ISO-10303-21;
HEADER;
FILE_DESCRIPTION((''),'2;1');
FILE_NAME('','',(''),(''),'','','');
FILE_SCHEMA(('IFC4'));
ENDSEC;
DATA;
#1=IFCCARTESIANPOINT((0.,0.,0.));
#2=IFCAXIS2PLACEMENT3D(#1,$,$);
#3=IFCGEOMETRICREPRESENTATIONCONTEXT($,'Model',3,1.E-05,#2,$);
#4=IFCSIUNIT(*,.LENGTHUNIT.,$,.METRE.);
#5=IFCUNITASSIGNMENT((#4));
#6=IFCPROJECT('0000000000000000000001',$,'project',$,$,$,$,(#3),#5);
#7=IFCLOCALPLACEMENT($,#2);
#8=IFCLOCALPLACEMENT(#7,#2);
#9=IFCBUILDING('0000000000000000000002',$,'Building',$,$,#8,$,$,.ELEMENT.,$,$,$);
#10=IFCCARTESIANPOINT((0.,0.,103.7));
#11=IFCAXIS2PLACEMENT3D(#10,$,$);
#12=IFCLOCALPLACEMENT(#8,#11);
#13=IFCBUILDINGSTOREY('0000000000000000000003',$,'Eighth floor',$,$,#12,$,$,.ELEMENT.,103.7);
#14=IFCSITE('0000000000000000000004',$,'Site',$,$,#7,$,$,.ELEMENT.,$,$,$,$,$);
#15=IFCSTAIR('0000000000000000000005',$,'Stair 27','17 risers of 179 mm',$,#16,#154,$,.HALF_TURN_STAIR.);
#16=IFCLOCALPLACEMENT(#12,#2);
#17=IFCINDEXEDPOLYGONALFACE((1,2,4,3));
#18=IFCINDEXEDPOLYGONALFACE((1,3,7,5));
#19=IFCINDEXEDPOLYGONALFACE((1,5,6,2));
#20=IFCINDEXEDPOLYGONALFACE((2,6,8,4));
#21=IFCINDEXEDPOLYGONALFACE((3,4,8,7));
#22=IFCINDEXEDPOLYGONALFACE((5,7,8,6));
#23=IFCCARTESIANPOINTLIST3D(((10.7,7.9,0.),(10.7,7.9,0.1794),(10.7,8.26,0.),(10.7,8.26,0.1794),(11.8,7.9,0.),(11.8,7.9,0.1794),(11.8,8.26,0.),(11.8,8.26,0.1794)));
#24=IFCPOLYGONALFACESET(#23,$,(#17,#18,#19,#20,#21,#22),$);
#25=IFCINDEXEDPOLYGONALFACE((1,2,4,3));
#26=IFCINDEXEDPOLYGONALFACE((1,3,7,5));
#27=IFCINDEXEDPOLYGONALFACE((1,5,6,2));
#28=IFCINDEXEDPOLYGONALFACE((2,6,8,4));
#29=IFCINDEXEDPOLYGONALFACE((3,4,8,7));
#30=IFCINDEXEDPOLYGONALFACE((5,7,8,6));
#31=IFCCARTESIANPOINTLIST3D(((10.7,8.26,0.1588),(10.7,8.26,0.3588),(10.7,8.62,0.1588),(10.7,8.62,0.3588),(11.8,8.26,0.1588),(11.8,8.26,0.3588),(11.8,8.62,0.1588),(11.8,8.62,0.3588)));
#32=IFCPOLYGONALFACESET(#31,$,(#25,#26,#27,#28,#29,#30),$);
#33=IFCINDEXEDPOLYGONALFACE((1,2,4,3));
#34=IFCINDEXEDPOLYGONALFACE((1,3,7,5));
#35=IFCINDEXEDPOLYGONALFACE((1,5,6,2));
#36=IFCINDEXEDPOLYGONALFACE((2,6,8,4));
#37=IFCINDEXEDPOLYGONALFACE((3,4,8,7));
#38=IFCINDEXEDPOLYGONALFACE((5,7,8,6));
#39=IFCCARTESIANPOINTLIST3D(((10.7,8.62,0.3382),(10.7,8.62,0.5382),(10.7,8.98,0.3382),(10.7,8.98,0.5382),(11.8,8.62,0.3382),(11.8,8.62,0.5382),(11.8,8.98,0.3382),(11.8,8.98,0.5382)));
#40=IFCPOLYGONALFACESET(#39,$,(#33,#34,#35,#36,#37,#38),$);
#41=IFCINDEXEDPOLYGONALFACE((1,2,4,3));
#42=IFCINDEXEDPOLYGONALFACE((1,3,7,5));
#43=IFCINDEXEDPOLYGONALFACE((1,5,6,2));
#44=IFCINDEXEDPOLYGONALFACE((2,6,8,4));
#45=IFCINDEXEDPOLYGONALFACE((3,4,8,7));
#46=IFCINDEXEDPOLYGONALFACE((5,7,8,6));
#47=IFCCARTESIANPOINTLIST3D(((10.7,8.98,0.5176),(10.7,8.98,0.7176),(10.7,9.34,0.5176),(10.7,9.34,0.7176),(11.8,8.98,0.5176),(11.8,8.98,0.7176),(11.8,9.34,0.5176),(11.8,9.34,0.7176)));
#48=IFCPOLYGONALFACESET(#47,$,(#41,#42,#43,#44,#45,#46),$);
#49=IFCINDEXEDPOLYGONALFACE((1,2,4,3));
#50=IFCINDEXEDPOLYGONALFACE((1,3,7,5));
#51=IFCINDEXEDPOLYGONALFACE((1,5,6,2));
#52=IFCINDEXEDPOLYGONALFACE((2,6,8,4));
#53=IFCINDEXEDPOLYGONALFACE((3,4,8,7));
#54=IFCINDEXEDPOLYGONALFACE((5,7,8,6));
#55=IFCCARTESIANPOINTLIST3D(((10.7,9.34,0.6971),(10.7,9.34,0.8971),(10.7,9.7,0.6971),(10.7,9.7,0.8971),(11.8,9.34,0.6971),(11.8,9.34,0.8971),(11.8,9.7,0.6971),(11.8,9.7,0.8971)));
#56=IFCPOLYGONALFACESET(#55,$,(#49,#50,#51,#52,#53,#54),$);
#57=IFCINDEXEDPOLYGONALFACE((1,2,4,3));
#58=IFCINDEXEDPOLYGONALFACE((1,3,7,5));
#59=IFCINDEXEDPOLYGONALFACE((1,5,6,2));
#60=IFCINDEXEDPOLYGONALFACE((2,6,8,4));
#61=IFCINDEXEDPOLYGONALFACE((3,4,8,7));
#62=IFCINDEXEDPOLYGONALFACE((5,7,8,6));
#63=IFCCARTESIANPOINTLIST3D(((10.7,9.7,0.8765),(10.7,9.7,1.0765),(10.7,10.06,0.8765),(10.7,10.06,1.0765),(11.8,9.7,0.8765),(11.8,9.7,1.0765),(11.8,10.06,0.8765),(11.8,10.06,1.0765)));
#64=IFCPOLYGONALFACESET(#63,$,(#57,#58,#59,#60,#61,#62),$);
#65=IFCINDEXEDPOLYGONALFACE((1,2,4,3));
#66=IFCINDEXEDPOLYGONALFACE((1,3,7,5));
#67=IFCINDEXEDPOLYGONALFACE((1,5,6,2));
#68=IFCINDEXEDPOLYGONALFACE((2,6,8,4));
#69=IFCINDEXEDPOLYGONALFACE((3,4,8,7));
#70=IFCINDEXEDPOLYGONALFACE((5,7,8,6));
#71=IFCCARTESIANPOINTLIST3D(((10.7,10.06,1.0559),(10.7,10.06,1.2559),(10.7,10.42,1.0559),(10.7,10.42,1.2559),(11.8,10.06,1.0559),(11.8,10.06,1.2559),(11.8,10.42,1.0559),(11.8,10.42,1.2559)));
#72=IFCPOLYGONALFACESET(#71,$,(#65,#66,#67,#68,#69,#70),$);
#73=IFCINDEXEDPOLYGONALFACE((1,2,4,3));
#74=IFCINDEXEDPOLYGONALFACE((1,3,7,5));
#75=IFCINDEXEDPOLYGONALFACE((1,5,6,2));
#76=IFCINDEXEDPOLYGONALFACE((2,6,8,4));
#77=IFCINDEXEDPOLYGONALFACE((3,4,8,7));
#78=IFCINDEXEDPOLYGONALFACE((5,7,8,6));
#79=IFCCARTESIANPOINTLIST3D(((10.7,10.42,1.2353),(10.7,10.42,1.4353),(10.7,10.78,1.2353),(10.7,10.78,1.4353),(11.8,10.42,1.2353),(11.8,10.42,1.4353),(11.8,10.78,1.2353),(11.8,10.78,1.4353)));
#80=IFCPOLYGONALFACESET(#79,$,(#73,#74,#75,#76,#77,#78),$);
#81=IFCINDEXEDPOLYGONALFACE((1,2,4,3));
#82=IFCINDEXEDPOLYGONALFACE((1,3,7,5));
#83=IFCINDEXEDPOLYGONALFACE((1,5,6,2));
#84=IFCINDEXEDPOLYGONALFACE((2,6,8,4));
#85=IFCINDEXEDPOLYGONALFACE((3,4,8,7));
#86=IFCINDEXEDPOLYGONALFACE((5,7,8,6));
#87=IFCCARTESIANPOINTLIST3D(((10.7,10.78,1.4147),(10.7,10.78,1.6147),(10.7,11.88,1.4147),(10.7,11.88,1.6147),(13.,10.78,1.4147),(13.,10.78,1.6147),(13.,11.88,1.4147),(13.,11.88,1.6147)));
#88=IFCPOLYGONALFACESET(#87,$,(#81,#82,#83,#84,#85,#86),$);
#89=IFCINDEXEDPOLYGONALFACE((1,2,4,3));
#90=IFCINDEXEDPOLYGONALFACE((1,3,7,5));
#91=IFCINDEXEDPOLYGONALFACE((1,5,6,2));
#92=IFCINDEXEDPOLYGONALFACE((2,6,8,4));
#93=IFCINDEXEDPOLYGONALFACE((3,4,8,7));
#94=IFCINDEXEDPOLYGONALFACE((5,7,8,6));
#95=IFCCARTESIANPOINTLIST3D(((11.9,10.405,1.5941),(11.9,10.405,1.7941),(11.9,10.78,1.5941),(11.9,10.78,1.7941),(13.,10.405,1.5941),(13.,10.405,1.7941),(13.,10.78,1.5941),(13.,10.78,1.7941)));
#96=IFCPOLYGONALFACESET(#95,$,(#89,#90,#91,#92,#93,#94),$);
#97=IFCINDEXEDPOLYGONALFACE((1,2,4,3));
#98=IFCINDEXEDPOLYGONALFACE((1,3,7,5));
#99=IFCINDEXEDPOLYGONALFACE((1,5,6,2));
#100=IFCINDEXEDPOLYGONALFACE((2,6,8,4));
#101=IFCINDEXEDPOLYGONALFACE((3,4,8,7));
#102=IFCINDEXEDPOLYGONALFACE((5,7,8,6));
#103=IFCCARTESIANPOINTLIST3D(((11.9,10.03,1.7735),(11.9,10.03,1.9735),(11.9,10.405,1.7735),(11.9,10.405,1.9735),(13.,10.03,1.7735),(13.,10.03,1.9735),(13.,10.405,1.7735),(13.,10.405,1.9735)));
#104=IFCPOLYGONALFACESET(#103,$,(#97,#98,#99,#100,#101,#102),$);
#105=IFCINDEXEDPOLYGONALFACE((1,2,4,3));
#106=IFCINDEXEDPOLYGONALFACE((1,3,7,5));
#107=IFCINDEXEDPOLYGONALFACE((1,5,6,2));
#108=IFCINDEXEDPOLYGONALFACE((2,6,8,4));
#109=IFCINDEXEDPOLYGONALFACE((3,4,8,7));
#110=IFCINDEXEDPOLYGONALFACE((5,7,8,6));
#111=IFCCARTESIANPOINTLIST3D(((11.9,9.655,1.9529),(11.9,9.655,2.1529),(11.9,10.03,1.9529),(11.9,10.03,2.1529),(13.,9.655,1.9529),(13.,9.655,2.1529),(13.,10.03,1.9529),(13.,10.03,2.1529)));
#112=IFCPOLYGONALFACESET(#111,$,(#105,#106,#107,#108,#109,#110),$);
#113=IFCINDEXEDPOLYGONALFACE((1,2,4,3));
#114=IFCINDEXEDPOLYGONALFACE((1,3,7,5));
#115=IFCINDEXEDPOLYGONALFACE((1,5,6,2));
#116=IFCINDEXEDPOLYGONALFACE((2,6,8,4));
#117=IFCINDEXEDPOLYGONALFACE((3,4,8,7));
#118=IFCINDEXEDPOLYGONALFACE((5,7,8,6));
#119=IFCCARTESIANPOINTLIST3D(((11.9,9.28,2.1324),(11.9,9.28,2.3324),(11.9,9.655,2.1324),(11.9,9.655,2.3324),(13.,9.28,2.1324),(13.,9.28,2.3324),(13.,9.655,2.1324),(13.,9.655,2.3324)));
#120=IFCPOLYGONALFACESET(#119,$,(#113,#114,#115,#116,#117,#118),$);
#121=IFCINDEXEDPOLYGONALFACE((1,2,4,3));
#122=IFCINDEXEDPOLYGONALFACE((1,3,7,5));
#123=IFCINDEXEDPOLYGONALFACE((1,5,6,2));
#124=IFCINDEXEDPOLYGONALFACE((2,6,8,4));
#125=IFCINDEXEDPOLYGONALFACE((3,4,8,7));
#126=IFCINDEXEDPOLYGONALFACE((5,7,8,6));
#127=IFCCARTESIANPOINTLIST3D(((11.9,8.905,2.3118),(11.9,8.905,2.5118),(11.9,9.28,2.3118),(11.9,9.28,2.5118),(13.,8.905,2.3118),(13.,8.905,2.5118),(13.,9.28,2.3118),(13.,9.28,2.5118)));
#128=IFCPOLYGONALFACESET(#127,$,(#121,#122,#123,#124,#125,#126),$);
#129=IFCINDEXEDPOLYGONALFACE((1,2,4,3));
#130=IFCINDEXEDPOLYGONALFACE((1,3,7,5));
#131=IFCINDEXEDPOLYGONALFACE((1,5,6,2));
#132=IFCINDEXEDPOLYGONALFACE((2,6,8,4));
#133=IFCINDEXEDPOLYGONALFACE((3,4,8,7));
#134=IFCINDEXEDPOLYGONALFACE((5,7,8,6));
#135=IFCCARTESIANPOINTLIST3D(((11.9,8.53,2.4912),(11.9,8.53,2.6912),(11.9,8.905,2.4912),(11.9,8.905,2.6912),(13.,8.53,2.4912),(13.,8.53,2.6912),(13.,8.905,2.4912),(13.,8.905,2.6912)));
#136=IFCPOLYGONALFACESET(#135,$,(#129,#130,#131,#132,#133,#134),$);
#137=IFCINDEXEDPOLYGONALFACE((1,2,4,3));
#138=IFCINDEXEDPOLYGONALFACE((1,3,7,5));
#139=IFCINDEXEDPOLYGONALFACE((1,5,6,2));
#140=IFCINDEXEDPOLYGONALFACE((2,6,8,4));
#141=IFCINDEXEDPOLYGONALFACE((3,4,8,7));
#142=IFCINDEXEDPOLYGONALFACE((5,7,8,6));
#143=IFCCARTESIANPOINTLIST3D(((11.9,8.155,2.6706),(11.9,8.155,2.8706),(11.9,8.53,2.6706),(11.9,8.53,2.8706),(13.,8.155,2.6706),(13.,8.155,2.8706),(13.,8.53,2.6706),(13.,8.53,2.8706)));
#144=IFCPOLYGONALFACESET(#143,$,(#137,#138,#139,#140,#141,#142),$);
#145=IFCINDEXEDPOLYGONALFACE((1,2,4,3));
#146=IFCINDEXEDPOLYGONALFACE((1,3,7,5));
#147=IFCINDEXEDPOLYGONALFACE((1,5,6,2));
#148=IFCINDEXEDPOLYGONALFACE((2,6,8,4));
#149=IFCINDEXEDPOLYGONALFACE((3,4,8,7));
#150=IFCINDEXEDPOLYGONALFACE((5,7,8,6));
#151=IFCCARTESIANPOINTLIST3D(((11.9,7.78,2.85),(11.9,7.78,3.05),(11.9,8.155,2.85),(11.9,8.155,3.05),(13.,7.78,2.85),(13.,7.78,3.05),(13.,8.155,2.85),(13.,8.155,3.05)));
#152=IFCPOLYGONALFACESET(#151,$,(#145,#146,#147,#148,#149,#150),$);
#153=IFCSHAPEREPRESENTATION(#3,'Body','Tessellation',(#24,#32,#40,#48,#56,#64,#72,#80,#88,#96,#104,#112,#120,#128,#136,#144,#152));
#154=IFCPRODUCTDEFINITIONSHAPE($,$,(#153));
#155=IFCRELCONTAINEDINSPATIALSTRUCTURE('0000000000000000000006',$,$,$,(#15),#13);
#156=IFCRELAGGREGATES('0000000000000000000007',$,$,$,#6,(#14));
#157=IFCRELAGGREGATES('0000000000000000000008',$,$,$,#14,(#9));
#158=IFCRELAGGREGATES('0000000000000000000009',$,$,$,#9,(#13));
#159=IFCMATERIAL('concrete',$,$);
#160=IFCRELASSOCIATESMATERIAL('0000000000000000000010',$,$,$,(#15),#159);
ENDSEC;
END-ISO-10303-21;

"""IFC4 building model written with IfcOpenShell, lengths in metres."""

from ifc_helpers import new_model, si_unit, frame, origin, place, context, project, spatial, polyline, outline, extrude, material, element, save


model = new_model("IFC4")

# Units and contexts
model_context = context("Model", 3, precision=1e-05, world=origin())
ifc_project = project(units=[si_unit("LENGTHUNIT", "METRE")], contexts=[model_context])

# Site, building, storey
site_placement = place(None, origin())
site = spatial("IfcSite", under=ifc_project, at=site_placement, Name="Site", CompositionType="ELEMENT")
building_placement = place(site_placement, origin())
building = spatial("IfcBuilding", under=site, at=building_placement, Name="Building", CompositionType="ELEMENT")
storey_placement = place(building_placement, frame((0.0, 0.0, 103.7)))
storey = spatial("IfcBuildingStorey", under=building, at=storey_placement, Name="Eighth floor", CompositionType="ELEMENT", Elevation=103.7)

# Shared definitions
ifc_material = material(Name="concrete")

# Stair
stair_placement = place(storey_placement, frame((11.25, 7.9, 0.0), z_axis=(0.0, 0.0, 1.0), x_axis=(0.0, 1.0, 0.0)))
element("IfcStair", 1, at=stair_placement, inside=storey, material=ifc_material, Name="Stair 27", Description="17 risers of 179 mm", PredefinedType="HALF_TURN_STAIR", context=model_context, shape_type="SweptSolid", body=[
    extrude(outline(polyline([(0.0, -0.55), (0.36, -0.55), (0.36, 0.55), (0.0, 0.55), (0.0, -0.55)])), origin(), (0.0, 0.0, 1.0), 0.1794),
    extrude(outline(polyline([(0.36, -0.55), (0.72, -0.55), (0.72, 0.55), (0.36, 0.55), (0.36, -0.55)])), frame((0.0, 0.0, 0.1588)), (0.0, 0.0, 1.0), 0.2),
    extrude(outline(polyline([(0.72, -0.55), (1.08, -0.55), (1.08, 0.55), (0.72, 0.55), (0.72, -0.55)])), frame((0.0, 0.0, 0.3382)), (0.0, 0.0, 1.0), 0.2),
    extrude(outline(polyline([(1.08, -0.55), (1.44, -0.55), (1.44, 0.55), (1.08, 0.55), (1.08, -0.55)])), frame((0.0, 0.0, 0.5176)), (0.0, 0.0, 1.0), 0.2),
    extrude(outline(polyline([(1.44, -0.55), (1.8, -0.55), (1.8, 0.55), (1.44, 0.55), (1.44, -0.55)])), frame((0.0, 0.0, 0.6971)), (0.0, 0.0, 1.0), 0.2),
    extrude(outline(polyline([(1.8, -0.55), (2.16, -0.55), (2.16, 0.55), (1.8, 0.55), (1.8, -0.55)])), frame((0.0, 0.0, 0.8765)), (0.0, 0.0, 1.0), 0.2),
    extrude(outline(polyline([(2.16, -0.55), (2.52, -0.55), (2.52, 0.55), (2.16, 0.55), (2.16, -0.55)])), frame((0.0, 0.0, 1.0559)), (0.0, 0.0, 1.0), 0.2),
    extrude(outline(polyline([(2.52, -0.55), (2.88, -0.55), (2.88, 0.55), (2.52, 0.55), (2.52, -0.55)])), frame((0.0, 0.0, 1.2353)), (0.0, 0.0, 1.0), 0.2),
    extrude(outline(polyline([(2.88, -1.75), (3.98, -1.75), (3.98, 0.55), (2.88, 0.55), (2.88, -1.75)])), frame((0.0, 0.0, 1.4147)), (0.0, 0.0, 1.0), 0.2),
    extrude(outline(polyline([(2.505, -1.75), (2.88, -1.75), (2.88, -0.65), (2.505, -0.65), (2.505, -1.75)])), frame((0.0, 0.0, 1.5941)), (0.0, 0.0, 1.0), 0.2),
    extrude(outline(polyline([(2.13, -1.75), (2.505, -1.75), (2.505, -0.65), (2.13, -0.65), (2.13, -1.75)])), frame((0.0, 0.0, 1.7735)), (0.0, 0.0, 1.0), 0.2),
    extrude(outline(polyline([(1.755, -1.75), (2.13, -1.75), (2.13, -0.65), (1.755, -0.65), (1.755, -1.75)])), frame((0.0, 0.0, 1.9529)), (0.0, 0.0, 1.0), 0.2),
    extrude(outline(polyline([(1.38, -1.75), (1.755, -1.75), (1.755, -0.65), (1.38, -0.65), (1.38, -1.75)])), frame((0.0, 0.0, 2.1324)), (0.0, 0.0, 1.0), 0.2),
    extrude(outline(polyline([(1.005, -1.75), (1.38, -1.75), (1.38, -0.65), (1.005, -0.65), (1.005, -1.75)])), frame((0.0, 0.0, 2.3118)), (0.0, 0.0, 1.0), 0.2),
    extrude(outline(polyline([(0.63, -1.75), (1.005, -1.75), (1.005, -0.65), (0.63, -0.65), (0.63, -1.75)])), frame((0.0, 0.0, 2.4912)), (0.0, 0.0, 1.0), 0.2),
    extrude(outline(polyline([(0.255, -1.75), (0.63, -1.75), (0.63, -0.65), (0.255, -0.65), (0.255, -1.75)])), frame((0.0, 0.0, 2.6706)), (0.0, 0.0, 1.0), 0.2),
    extrude(outline(polyline([(-0.12, -1.75), (0.255, -1.75), (0.255, -0.65), (-0.12, -0.65), (-0.12, -1.75)])), frame((0.0, 0.0, 2.85)), (0.0, 0.0, 1.0), 0.2),
])

save(model, "model.ifc")
